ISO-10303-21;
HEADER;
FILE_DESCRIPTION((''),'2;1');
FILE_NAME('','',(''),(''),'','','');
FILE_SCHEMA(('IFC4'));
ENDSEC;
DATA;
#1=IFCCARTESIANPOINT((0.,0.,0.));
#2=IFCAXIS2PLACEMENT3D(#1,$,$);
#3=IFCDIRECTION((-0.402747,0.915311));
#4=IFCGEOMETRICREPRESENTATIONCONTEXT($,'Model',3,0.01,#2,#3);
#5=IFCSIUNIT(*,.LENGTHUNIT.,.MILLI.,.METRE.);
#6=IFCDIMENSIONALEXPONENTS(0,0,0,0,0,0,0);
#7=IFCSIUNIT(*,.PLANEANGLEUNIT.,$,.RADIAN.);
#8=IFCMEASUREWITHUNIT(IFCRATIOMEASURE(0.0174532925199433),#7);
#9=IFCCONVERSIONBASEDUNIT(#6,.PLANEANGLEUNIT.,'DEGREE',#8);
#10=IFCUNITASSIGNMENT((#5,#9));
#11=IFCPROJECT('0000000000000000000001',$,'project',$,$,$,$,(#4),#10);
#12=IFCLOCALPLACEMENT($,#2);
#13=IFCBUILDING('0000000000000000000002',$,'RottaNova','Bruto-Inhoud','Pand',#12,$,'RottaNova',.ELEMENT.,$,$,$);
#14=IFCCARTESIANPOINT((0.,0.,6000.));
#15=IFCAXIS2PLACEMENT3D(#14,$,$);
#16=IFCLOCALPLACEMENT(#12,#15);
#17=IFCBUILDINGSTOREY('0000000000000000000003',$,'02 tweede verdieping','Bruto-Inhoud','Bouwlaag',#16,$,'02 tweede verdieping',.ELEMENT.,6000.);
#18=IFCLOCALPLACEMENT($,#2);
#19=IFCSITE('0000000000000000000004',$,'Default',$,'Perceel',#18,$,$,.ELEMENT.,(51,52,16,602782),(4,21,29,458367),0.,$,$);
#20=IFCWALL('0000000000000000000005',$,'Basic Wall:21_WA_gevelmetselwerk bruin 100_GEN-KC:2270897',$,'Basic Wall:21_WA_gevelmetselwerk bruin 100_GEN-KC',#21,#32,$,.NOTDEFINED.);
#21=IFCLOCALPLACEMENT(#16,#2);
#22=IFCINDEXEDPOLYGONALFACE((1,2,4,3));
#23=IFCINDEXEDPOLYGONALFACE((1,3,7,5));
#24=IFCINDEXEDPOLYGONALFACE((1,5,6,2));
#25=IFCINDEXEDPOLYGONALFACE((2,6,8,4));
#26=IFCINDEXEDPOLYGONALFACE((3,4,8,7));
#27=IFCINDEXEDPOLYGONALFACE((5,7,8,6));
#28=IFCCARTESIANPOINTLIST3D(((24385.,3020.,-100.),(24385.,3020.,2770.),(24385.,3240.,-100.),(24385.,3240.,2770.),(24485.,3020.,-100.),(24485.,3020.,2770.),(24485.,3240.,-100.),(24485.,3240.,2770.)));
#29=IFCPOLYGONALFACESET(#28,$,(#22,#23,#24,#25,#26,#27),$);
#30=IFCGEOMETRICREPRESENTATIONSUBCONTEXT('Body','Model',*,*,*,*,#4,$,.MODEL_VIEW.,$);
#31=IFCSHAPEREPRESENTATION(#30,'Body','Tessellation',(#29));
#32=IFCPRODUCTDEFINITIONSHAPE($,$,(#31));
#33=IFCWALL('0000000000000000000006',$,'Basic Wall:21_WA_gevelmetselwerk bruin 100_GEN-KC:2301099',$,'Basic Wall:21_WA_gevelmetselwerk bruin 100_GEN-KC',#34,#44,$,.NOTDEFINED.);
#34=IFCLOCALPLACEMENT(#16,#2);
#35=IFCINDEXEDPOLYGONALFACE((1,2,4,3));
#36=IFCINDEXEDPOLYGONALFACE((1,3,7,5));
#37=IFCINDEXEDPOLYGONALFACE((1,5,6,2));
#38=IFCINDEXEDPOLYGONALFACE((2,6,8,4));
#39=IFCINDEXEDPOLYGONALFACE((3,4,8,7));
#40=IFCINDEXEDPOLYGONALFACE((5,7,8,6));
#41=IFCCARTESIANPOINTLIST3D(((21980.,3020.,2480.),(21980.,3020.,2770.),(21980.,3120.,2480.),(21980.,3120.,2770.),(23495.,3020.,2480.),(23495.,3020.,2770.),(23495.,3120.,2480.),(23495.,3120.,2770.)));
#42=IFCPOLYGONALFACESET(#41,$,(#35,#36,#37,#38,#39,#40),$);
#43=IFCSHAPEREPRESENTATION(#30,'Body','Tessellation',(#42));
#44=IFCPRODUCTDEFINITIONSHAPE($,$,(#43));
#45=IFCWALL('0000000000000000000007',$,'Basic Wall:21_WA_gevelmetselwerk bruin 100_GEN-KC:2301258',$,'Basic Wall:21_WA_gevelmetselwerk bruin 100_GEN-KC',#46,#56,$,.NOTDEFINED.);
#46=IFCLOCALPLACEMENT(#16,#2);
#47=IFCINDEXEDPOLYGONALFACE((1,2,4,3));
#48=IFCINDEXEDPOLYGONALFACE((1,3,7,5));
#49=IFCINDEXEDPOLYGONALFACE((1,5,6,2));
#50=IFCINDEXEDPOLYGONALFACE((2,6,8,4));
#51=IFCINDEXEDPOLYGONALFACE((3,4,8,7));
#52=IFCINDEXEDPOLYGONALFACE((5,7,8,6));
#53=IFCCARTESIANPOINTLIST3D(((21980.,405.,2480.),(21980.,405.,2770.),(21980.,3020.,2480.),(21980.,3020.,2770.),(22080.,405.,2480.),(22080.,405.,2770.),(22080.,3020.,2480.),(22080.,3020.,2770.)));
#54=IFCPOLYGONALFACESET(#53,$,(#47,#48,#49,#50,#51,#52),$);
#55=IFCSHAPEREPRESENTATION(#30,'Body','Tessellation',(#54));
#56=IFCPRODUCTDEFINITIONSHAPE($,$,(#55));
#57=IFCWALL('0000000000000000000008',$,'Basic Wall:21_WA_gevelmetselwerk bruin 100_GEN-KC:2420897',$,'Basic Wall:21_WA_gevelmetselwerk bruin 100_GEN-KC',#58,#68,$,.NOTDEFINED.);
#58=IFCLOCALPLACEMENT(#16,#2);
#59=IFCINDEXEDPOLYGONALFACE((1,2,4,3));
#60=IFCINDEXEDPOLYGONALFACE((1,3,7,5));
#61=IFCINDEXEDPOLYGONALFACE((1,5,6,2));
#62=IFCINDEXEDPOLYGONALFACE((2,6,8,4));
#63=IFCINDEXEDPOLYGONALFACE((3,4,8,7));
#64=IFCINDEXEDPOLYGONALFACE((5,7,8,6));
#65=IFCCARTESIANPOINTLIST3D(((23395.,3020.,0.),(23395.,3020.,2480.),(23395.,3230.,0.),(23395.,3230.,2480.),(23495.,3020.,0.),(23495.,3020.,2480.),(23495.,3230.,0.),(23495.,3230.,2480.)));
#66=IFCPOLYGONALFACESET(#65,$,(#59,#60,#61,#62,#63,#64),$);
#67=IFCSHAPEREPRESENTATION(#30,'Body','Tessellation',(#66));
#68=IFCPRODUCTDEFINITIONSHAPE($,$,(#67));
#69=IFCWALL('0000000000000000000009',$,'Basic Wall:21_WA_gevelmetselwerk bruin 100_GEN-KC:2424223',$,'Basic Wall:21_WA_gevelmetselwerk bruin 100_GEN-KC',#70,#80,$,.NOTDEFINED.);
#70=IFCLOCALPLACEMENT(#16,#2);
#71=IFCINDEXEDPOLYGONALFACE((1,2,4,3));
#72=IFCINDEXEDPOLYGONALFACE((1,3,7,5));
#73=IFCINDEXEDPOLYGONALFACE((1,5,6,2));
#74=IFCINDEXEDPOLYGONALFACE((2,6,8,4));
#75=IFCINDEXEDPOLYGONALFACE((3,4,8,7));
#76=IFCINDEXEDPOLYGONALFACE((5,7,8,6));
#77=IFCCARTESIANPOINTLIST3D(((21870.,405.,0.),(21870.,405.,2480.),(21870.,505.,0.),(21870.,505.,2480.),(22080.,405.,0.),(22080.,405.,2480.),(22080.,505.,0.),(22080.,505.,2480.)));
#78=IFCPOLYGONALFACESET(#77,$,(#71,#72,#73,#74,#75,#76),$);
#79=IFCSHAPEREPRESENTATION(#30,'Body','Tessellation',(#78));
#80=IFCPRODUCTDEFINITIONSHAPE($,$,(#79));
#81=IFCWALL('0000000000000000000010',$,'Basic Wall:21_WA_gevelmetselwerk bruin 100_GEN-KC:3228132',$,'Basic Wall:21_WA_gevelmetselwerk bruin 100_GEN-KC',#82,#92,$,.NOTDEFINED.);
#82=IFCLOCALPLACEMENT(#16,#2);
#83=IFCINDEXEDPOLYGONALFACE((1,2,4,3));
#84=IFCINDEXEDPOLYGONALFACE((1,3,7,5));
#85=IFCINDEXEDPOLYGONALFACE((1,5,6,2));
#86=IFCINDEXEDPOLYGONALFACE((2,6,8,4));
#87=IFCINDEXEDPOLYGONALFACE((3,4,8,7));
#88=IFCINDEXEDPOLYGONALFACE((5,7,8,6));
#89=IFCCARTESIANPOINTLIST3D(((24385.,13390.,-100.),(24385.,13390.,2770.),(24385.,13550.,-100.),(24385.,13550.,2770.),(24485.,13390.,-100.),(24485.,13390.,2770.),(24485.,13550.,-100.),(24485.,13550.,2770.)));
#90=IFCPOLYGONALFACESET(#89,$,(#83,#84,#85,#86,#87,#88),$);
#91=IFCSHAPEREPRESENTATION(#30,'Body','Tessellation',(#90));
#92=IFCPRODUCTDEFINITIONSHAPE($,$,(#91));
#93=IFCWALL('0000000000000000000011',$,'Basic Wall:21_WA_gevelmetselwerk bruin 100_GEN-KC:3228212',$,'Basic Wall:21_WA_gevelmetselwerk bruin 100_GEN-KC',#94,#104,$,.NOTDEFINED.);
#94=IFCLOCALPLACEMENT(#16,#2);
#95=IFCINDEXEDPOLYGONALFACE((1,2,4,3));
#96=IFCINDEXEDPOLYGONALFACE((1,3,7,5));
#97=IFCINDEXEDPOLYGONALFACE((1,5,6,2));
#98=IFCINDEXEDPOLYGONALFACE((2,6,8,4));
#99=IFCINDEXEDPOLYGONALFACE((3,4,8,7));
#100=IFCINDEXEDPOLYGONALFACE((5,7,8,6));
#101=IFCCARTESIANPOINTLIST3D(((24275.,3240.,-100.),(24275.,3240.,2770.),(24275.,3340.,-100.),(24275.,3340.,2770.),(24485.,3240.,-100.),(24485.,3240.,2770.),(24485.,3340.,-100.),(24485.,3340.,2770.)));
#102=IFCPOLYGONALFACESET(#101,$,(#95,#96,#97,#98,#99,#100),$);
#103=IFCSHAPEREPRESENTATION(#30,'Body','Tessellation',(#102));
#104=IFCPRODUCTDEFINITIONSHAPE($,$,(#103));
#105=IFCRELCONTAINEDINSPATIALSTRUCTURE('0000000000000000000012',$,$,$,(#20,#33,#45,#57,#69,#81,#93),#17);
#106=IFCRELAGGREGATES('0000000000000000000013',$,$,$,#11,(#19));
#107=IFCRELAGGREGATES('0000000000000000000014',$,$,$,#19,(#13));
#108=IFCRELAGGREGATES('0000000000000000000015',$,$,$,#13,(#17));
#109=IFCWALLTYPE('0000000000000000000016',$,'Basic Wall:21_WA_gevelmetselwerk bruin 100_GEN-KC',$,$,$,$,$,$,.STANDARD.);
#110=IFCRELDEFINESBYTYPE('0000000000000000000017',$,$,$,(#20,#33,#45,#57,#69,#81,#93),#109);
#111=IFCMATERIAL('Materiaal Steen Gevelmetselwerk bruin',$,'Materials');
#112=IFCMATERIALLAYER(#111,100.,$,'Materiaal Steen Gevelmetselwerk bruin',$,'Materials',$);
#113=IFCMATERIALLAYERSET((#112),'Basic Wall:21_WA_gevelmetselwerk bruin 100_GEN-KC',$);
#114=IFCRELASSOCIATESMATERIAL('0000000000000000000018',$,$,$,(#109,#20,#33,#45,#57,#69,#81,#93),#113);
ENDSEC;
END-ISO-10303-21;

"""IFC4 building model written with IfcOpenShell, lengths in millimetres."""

from ifc_helpers import new_model, entity, si_unit, converted_unit, direction, frame, frame_2d, origin, place, context, subcontext, project, spatial, rectangle, extrude, material, layer, layer_set, type_object, element, save


model = new_model("IFC4")

# Units and contexts
model_context = context("Model", 3, precision=0.01, world=origin(), true_north=direction((-0.402747, 0.915311)))
body_context = subcontext(model_context, "Body", "Model", "MODEL_VIEW")
ifc_project = project(units=[si_unit("LENGTHUNIT", "METRE", prefix="MILLI"), converted_unit("PLANEANGLEUNIT", "DEGREE", entity("IfcRatioMeasure", 0.0174532925199433), si_unit("PLANEANGLEUNIT", "RADIAN"), dimensions=[0, 0, 0, 0, 0, 0, 0])], contexts=[model_context])

# Site, building, storey
site_placement = place(None, origin())
site = spatial("IfcSite", under=ifc_project, at=site_placement, Name="Default", ObjectType="Perceel", CompositionType="ELEMENT", RefLatitude=(51, 52, 16, 602782), RefLongitude=(4, 21, 29, 458367), RefElevation=0.0)
building_placement = place(None, origin())
building = spatial("IfcBuilding", under=site, at=building_placement, Name="RottaNova", Description="Bruto-Inhoud", ObjectType="Pand", LongName="RottaNova", CompositionType="ELEMENT")
storey_placement = place(building_placement, frame((0.0, 0.0, 6000.0)))
storey = spatial("IfcBuildingStorey", under=building, at=storey_placement, Name="02 tweede verdieping", Description="Bruto-Inhoud", ObjectType="Bouwlaag", LongName="02 tweede verdieping", CompositionType="ELEMENT", Elevation=6000.0)

# Walls
ifc_material_1 = material(Name="Materiaal Steen Gevelmetselwerk bruin", Category="Materials")
ifc_layer_1 = layer(ifc_material_1, 100.0, Name="Materiaal Steen Gevelmetselwerk bruin", Category="Materials")
ifc_layer_set_1 = layer_set([ifc_layer_1], Name="Basic Wall:21_WA_gevelmetselwerk bruin 100_GEN-KC")
wall_type_1 = type_object("IfcWallType", Name="Basic Wall:21_WA_gevelmetselwerk bruin 100_GEN-KC", PredefinedType="STANDARD", material=ifc_layer_set_1)
wall_1_placement = place(storey_placement, frame((24435.0, 3240.0, -100.0), z_axis=(0.0, 0.0, 1.0), x_axis=(0.0, -1.0, 0.0)))
element("IfcWall", 1, at=wall_1_placement, inside=storey, type_object=wall_type_1, material=ifc_layer_set_1, Name="Basic Wall:21_WA_gevelmetselwerk bruin 100_GEN-KC:2270897", ObjectType="Basic Wall:21_WA_gevelmetselwerk bruin 100_GEN-KC", PredefinedType="NOTDEFINED", context=body_context, shape_type="SweptSolid", body=[
    extrude(rectangle(XDim=220.0, YDim=100.0, at=frame_2d((110.0, 0.0), x_axis=(-1.0, 0.0))), origin(), (0.0, 0.0, 1.0), 2870.0),
])
wall_2_placement = place(storey_placement, frame((23495.0, 3070.0, 2480.0), z_axis=(0.0, 0.0, 1.0), x_axis=(-1.0, 0.0, 0.0)))
element("IfcWall", 2, at=wall_2_placement, inside=storey, type_object=wall_type_1, material=ifc_layer_set_1, Name="Basic Wall:21_WA_gevelmetselwerk bruin 100_GEN-KC:2301099", ObjectType="Basic Wall:21_WA_gevelmetselwerk bruin 100_GEN-KC", PredefinedType="NOTDEFINED", context=body_context, shape_type="SweptSolid", body=[
    extrude(rectangle(XDim=1515.0, YDim=100.0, at=frame_2d((757.5, 0.0), x_axis=(-1.0, 0.0))), origin(), (0.0, 0.0, 1.0), 290.0),
])
wall_3_placement = place(storey_placement, frame((22030.0, 3020.0, 2480.0), z_axis=(0.0, 0.0, 1.0), x_axis=(0.0, -1.0, 0.0)))
element("IfcWall", 3, at=wall_3_placement, inside=storey, type_object=wall_type_1, material=ifc_layer_set_1, Name="Basic Wall:21_WA_gevelmetselwerk bruin 100_GEN-KC:2301258", ObjectType="Basic Wall:21_WA_gevelmetselwerk bruin 100_GEN-KC", PredefinedType="NOTDEFINED", context=body_context, shape_type="SweptSolid", body=[
    extrude(rectangle(XDim=2615.0, YDim=100.0, at=frame_2d((1307.5, 0.0), x_axis=(-1.0, 0.0))), origin(), (0.0, 0.0, 1.0), 290.0),
])
wall_4_placement = place(storey_placement, frame((23445.0, 3230.0, 0.0), z_axis=(0.0, 0.0, 1.0), x_axis=(0.0, -1.0, 0.0)))
element("IfcWall", 4, at=wall_4_placement, inside=storey, type_object=wall_type_1, material=ifc_layer_set_1, Name="Basic Wall:21_WA_gevelmetselwerk bruin 100_GEN-KC:2420897", ObjectType="Basic Wall:21_WA_gevelmetselwerk bruin 100_GEN-KC", PredefinedType="NOTDEFINED", context=body_context, shape_type="SweptSolid", body=[
    extrude(rectangle(XDim=210.0, YDim=100.0, at=frame_2d((105.0, 0.0), x_axis=(-1.0, 0.0))), origin(), (0.0, 0.0, 1.0), 2480.0),
])
wall_5_placement = place(storey_placement, frame((21870.0, 455.0, 0.0)))
element("IfcWall", 5, at=wall_5_placement, inside=storey, type_object=wall_type_1, material=ifc_layer_set_1, Name="Basic Wall:21_WA_gevelmetselwerk bruin 100_GEN-KC:2424223", ObjectType="Basic Wall:21_WA_gevelmetselwerk bruin 100_GEN-KC", PredefinedType="NOTDEFINED", context=body_context, shape_type="SweptSolid", body=[
    extrude(rectangle(XDim=210.0, YDim=100.0, at=frame_2d((105.0, 0.0), x_axis=(-1.0, 0.0))), origin(), (0.0, 0.0, 1.0), 2480.0),
])
wall_6_placement = place(storey_placement, frame((24435.0, 13390.0, -100.0), z_axis=(0.0, 0.0, 1.0), x_axis=(0.0, 1.0, 0.0)))
element("IfcWall", 6, at=wall_6_placement, inside=storey, type_object=wall_type_1, material=ifc_layer_set_1, Name="Basic Wall:21_WA_gevelmetselwerk bruin 100_GEN-KC:3228132", ObjectType="Basic Wall:21_WA_gevelmetselwerk bruin 100_GEN-KC", PredefinedType="NOTDEFINED", context=body_context, shape_type="SweptSolid", body=[
    extrude(rectangle(XDim=160.0, YDim=100.0, at=frame_2d((80.0, 0.0), x_axis=(-1.0, 0.0))), origin(), (0.0, 0.0, 1.0), 2870.0),
])
wall_7_placement = place(storey_placement, frame((24485.0, 3290.0, -100.0), z_axis=(0.0, 0.0, 1.0), x_axis=(-1.0, 0.0, 0.0)))
element("IfcWall", 7, at=wall_7_placement, inside=storey, type_object=wall_type_1, material=ifc_layer_set_1, Name="Basic Wall:21_WA_gevelmetselwerk bruin 100_GEN-KC:3228212", ObjectType="Basic Wall:21_WA_gevelmetselwerk bruin 100_GEN-KC", PredefinedType="NOTDEFINED", context=body_context, shape_type="SweptSolid", body=[
    extrude(rectangle(XDim=210.0, YDim=100.0, at=frame_2d((105.0, 0.0), x_axis=(-1.0, 0.0))), origin(), (0.0, 0.0, 1.0), 2870.0),
])

save(model, "model.ifc")
